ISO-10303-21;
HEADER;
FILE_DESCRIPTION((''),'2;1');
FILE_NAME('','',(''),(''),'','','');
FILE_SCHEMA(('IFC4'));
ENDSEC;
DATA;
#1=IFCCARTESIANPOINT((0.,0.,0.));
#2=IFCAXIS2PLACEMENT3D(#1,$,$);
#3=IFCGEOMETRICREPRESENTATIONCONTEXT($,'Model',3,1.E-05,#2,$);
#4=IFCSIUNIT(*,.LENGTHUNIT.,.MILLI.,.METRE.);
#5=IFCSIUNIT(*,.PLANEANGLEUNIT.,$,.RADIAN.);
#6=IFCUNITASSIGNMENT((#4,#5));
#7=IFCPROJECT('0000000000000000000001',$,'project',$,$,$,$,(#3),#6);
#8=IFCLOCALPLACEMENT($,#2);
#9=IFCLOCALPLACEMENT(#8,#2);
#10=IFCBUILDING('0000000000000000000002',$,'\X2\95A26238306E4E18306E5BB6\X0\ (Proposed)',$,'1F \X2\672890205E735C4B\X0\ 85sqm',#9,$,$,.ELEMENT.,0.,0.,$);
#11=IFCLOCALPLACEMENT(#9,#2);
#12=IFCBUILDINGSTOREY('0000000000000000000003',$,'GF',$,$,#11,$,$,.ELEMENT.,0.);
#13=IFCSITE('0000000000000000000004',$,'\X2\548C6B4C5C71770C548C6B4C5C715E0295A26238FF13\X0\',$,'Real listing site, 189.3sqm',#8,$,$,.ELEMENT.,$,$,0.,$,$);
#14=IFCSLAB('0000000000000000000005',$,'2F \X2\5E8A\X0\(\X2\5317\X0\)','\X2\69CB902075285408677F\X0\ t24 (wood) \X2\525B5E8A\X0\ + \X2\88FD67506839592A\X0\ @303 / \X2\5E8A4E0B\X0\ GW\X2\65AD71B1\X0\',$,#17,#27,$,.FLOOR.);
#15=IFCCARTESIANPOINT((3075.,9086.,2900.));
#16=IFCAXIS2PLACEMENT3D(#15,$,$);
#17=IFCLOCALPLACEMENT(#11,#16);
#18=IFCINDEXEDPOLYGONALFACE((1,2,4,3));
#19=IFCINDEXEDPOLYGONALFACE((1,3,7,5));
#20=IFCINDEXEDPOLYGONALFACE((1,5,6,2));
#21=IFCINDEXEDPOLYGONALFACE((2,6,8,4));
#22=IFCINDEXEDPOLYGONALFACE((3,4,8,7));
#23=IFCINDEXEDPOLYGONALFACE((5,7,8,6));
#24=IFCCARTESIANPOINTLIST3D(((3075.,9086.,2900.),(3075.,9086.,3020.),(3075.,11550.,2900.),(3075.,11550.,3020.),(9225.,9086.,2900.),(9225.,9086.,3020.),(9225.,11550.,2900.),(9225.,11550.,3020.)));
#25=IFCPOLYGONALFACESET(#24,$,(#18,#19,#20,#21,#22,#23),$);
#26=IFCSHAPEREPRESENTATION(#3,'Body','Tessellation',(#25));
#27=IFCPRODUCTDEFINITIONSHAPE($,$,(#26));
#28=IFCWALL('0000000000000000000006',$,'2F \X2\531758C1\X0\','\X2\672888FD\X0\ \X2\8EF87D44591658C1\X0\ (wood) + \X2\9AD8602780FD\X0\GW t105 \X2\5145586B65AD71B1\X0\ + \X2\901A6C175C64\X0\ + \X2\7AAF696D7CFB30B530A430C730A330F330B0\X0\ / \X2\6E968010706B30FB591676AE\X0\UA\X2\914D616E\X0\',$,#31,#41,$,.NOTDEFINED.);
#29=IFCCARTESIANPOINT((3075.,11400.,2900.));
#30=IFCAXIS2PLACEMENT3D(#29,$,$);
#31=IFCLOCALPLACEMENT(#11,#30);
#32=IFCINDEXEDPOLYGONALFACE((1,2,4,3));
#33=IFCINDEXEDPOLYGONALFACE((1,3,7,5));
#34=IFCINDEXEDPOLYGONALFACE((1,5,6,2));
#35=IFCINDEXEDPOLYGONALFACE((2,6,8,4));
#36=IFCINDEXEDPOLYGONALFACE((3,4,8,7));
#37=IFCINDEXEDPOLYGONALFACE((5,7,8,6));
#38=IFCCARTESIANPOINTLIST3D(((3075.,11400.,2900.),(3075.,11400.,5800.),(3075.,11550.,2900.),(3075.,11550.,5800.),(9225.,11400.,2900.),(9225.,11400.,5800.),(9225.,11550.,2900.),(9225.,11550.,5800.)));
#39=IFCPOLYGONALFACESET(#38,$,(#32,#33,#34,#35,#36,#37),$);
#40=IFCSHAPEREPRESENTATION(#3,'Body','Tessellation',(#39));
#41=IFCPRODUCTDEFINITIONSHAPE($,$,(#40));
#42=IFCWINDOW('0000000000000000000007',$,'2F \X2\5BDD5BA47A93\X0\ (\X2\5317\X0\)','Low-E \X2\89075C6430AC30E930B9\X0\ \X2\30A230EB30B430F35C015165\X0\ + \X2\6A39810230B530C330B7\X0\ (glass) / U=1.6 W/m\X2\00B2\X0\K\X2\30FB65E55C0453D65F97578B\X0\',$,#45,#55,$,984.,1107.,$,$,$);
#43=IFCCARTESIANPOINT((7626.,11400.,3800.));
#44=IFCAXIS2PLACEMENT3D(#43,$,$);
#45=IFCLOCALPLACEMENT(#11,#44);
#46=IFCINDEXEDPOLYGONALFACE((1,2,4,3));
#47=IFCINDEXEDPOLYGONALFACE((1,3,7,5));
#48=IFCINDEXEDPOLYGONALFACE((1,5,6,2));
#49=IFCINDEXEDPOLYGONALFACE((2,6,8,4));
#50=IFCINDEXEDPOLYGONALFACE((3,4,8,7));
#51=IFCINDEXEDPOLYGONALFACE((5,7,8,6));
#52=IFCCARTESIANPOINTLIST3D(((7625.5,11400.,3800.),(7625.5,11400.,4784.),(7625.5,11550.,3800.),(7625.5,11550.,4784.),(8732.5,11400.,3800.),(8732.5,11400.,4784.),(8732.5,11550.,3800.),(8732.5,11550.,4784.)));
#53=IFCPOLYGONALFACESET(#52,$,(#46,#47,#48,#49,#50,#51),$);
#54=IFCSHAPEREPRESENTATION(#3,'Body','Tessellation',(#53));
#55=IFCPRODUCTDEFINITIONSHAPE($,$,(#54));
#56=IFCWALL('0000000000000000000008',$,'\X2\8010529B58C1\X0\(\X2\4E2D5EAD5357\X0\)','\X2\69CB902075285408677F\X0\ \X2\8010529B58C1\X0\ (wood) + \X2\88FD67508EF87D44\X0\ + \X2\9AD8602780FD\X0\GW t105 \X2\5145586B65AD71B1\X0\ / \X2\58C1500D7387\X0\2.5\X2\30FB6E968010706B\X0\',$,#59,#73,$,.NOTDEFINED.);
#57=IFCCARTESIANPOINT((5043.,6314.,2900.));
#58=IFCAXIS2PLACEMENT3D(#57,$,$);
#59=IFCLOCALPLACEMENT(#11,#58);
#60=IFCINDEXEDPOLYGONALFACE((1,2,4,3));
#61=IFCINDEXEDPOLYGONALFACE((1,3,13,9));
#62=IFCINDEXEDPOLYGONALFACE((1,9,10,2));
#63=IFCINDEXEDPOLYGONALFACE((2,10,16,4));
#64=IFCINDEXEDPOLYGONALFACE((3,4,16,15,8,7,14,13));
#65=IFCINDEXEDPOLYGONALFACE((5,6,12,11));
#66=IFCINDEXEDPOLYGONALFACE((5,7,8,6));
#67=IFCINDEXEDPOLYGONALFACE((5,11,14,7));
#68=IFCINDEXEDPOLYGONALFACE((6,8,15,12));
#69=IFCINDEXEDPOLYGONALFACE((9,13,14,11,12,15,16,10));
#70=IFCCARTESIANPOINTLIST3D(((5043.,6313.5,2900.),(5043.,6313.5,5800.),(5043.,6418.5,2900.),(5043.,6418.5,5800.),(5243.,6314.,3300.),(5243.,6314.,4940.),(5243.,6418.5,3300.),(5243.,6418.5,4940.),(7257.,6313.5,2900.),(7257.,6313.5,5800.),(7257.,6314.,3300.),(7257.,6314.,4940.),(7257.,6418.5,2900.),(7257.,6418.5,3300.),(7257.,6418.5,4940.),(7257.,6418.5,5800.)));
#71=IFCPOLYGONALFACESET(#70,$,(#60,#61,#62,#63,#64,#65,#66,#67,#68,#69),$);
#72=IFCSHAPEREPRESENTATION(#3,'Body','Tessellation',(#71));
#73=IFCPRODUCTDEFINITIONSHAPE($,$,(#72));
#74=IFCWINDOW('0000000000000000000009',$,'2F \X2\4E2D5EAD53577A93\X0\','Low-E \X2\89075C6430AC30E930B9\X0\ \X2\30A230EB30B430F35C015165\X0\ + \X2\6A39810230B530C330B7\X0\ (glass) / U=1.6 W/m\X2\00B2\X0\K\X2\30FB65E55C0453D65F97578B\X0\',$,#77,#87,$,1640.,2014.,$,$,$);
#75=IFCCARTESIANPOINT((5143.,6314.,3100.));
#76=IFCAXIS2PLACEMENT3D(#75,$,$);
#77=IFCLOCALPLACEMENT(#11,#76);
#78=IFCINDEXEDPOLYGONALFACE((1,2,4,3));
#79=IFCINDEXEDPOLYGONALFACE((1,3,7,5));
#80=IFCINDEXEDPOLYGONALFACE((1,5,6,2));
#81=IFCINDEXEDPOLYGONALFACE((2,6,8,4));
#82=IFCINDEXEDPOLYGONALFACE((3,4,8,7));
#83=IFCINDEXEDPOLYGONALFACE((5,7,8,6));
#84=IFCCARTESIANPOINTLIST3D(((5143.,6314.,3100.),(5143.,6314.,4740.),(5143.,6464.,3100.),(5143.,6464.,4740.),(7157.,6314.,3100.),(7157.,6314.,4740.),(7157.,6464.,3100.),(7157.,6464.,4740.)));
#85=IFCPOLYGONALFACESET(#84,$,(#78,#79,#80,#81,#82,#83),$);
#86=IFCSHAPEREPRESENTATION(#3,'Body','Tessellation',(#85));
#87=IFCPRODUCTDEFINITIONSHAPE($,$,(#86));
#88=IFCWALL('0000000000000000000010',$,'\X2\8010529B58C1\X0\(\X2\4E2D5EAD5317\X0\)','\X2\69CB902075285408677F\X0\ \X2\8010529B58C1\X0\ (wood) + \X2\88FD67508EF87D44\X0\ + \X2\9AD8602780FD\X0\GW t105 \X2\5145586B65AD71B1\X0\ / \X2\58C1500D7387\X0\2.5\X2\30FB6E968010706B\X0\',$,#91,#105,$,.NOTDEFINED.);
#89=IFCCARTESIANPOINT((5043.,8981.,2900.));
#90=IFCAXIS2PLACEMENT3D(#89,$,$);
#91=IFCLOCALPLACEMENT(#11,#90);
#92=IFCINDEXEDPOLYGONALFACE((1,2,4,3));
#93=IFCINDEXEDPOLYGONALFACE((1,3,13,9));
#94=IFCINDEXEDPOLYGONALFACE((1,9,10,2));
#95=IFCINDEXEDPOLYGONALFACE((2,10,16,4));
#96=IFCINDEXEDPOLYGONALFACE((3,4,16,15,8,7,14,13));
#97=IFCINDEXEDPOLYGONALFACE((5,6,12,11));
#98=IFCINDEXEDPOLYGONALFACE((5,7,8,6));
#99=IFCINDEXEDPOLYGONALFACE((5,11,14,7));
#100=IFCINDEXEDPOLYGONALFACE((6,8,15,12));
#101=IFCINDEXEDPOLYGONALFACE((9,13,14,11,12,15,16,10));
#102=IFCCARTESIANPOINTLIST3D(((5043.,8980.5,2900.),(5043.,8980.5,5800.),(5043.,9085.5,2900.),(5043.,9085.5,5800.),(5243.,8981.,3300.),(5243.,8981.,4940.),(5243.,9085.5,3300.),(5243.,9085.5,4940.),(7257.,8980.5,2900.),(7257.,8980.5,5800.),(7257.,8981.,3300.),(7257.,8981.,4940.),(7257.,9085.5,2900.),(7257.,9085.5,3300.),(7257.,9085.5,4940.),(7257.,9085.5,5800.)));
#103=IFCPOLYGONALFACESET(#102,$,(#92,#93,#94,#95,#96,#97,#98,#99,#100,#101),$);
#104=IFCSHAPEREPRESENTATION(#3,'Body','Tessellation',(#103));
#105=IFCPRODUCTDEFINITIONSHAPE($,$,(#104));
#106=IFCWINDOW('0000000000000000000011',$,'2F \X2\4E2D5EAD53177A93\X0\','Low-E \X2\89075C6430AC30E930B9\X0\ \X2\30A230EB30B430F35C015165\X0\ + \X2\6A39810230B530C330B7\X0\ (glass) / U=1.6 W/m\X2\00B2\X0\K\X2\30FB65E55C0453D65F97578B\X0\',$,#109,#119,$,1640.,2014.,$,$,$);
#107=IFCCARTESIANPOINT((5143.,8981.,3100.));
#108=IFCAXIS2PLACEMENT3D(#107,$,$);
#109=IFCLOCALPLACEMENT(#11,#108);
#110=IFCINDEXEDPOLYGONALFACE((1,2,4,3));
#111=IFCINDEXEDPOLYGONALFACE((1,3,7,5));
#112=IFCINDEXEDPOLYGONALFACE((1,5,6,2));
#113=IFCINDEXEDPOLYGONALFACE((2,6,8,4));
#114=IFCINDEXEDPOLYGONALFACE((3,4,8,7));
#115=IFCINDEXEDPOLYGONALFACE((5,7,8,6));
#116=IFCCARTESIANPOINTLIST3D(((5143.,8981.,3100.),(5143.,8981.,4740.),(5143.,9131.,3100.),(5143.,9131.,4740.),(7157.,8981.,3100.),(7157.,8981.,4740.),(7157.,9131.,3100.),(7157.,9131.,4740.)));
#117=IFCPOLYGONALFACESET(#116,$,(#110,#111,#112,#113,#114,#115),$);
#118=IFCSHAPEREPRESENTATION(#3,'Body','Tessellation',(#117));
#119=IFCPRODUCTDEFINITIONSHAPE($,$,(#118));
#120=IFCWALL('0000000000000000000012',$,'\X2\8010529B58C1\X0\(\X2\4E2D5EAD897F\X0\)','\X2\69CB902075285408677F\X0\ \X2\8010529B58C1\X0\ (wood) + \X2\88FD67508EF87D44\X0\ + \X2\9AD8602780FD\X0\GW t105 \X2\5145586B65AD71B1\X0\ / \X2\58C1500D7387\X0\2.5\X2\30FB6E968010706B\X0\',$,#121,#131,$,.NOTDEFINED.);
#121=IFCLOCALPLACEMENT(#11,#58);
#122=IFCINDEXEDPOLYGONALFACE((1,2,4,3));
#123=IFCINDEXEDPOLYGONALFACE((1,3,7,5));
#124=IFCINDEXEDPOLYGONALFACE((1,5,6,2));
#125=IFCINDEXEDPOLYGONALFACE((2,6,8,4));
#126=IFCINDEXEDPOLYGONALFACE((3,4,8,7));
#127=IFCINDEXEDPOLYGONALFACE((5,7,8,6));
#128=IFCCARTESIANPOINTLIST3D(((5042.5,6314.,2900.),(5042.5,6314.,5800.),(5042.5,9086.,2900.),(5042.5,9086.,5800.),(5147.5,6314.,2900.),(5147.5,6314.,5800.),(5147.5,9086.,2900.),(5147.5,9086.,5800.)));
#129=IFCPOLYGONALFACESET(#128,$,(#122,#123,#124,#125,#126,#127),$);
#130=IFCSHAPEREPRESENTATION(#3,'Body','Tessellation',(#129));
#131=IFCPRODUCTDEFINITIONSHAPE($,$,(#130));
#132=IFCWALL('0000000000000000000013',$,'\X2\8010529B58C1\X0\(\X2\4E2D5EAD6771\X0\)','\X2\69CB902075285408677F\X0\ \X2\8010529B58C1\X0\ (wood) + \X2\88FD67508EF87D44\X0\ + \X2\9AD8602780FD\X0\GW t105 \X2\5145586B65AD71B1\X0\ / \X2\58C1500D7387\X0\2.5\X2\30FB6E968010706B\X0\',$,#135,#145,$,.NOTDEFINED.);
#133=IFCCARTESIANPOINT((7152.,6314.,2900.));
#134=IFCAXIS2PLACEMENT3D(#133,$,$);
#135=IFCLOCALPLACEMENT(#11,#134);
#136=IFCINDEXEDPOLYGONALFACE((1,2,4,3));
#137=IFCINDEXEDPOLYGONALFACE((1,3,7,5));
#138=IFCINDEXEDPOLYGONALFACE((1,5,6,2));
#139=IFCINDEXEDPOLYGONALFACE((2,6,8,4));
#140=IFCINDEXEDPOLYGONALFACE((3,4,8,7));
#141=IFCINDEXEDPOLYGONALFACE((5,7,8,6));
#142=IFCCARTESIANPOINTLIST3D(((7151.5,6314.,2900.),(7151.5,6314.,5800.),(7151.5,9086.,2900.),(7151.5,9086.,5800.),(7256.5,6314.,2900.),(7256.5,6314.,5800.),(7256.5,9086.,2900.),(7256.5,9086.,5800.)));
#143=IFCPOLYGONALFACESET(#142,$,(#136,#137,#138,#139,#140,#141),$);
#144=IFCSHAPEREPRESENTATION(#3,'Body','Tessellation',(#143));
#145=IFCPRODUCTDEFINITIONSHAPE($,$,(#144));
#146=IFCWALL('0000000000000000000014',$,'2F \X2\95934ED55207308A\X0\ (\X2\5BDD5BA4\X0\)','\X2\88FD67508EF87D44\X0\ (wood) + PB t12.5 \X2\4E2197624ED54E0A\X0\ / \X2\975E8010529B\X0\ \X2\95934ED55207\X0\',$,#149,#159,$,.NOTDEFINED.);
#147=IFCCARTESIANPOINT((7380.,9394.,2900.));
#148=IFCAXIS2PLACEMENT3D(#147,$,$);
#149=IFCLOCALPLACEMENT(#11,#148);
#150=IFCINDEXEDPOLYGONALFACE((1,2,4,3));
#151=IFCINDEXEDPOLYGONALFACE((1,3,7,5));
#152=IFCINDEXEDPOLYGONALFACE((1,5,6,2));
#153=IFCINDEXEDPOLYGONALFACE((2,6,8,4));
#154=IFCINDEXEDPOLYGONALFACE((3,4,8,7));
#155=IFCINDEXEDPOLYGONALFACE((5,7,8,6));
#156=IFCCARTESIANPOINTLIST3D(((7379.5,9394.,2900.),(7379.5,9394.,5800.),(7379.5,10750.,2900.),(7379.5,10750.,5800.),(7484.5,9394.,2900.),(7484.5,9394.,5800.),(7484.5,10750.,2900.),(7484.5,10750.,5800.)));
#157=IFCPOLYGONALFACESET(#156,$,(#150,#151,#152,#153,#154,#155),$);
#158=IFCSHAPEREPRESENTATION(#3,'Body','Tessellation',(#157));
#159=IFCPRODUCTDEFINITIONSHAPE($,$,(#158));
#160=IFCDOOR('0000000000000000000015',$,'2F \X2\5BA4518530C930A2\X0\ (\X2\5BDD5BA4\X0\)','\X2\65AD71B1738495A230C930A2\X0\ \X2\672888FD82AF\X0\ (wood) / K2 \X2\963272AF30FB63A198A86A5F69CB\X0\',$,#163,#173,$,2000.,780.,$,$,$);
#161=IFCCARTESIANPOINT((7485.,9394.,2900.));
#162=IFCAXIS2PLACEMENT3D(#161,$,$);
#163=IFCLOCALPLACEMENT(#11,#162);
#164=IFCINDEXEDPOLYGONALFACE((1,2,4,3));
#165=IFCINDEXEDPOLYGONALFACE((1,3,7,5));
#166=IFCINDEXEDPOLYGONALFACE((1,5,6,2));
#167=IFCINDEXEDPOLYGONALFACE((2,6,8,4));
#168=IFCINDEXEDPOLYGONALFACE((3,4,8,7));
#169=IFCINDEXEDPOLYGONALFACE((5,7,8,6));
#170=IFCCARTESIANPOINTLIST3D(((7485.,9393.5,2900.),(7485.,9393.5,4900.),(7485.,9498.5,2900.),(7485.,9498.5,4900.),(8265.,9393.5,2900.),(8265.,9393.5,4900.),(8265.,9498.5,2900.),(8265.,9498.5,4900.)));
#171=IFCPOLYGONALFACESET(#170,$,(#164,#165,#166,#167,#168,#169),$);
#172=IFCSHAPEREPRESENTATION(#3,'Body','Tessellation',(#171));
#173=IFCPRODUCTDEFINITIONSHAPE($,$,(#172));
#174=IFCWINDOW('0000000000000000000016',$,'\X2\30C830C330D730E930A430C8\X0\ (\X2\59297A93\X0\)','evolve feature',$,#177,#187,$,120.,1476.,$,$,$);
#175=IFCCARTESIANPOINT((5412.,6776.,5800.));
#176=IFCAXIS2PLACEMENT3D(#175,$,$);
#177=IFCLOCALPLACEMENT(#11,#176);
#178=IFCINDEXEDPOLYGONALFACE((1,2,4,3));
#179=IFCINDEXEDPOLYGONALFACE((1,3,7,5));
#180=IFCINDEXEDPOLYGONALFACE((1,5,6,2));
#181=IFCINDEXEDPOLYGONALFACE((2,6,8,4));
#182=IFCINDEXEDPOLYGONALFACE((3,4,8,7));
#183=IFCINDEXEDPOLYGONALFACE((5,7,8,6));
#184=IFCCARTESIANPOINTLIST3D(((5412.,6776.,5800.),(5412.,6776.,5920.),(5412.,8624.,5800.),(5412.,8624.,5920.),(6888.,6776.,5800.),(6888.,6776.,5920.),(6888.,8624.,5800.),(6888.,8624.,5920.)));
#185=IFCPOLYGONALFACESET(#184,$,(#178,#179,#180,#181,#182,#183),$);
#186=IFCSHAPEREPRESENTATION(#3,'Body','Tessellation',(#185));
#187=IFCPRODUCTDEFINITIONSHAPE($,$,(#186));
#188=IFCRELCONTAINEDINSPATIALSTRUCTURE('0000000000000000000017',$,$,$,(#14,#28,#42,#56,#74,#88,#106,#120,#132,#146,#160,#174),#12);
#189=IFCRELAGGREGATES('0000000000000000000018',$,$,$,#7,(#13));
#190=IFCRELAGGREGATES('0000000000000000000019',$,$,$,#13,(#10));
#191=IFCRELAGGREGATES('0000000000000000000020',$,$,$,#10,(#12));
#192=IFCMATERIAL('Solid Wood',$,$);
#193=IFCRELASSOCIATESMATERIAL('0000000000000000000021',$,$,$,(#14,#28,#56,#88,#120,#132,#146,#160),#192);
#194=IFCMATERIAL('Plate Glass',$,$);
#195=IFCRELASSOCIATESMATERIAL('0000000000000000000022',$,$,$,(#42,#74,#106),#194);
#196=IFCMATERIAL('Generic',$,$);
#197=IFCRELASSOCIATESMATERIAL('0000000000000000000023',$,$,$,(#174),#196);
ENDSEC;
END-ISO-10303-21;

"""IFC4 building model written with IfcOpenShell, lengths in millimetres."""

from ifc_helpers import new_model, si_unit, frame, frame_2d, origin, place, context, project, spatial, rectangle, extrude, material, element, fill, save


model = new_model("IFC4")

# Units and contexts
model_context = context("Model", 3, precision=1e-05, world=origin())
ifc_project = project(units=[si_unit("LENGTHUNIT", "METRE", prefix="MILLI"), si_unit("PLANEANGLEUNIT", "RADIAN")], contexts=[model_context])

# Site, building, storey
site_placement = place(None, origin())
site = spatial("IfcSite", under=ifc_project, at=site_placement, Name="和歌山県和歌山市関戸３", ObjectType="Real listing site, 189.3sqm", CompositionType="ELEMENT", RefElevation=0.0)
building_placement = place(site_placement, origin())
building = spatial("IfcBuilding", under=site, at=building_placement, Name="関戸の丘の家 (Proposed)", ObjectType="1F 木造平屋 85sqm", CompositionType="ELEMENT", ElevationOfRefHeight=0.0, ElevationOfTerrain=0.0)
storey_placement = place(building_placement, origin())
storey = spatial("IfcBuildingStorey", under=building, at=storey_placement, Name="GF", CompositionType="ELEMENT", Elevation=0.0)

# Slab
ifc_material_1 = material(Name="Solid Wood")
slab_placement = place(storey_placement, frame((3075.0, 9086.0, 2900.0)))
element("IfcSlab", 1, at=slab_placement, inside=storey, material=ifc_material_1, Name="2F 床(北)", Description="構造用合板 t24 (wood) 剛床 + 製材根太 @303 / 床下 GW断熱", PredefinedType="FLOOR", context=model_context, shape_type="SweptSolid", body=[
    extrude(rectangle(XDim=6150.0, YDim=2464.0, at=frame_2d((3075.0, 1232.0))), frame((3075.0, 9086.0, 2900.0)), (0.0, 0.0, 1.0), 120.0),
])

# Walls, openings, windows
wall_1_placement = place(storey_placement, frame((3075.0, 11400.0, 2900.0)))
wall_1 = element("IfcWall", 2, at=wall_1_placement, inside=storey, material=ifc_material_1, Name="2F 北壁", Description="木製 軸組外壁 (wood) + 高性能GW t105 充填断熱 + 通気層 + 窯業系サイディング / 準耐火・外皮UA配慮", PredefinedType="NOTDEFINED", context=model_context, shape_type="SweptSolid", body=[
    extrude(rectangle(XDim=6150.0, YDim=150.0, at=frame_2d((3075.0, 75.0))), frame((3075.0, 11400.0, 2900.0)), (0.0, 0.0, 1.0), 2900.0),
])
opening_1_placement = place(storey_placement, frame((7626.0, 11400.0, 3800.0)))
opening_1 = element("IfcOpeningElement", 3, at=opening_1_placement, cuts=wall_1, PredefinedType="NOTDEFINED", context=model_context, shape_type="SweptSolid", body=[
    extrude(rectangle(XDim=1107.0, YDim=150.0, at=frame_2d((553.0, 75.0))), frame((7626.0, 11400.0, 3800.0)), (0.0, 0.0, 1.0), 984.0),
])
ifc_material_2 = material(Name="Plate Glass")
window_1_placement = place(storey_placement, frame((7626.0, 11400.0, 3800.0)))
window_1 = element("IfcWindow", 4, at=window_1_placement, inside=storey, material=ifc_material_2, Name="2F 寝室窓 (北)", Description="Low-E 複層ガラス アルゴン封入 + 樹脂サッシ (glass) / U=1.6 W/m²K・日射取得型", OverallHeight=984.0, OverallWidth=1107.0, context=model_context, shape_type="SweptSolid", body=[
    extrude(rectangle(XDim=1107.0, YDim=150.0, at=frame_2d((553.0, 75.0))), frame((7626.0, 11400.0, 3800.0)), (0.0, 0.0, 1.0), 984.0),
])
fill(opening_1, window_1)
wall_2_placement = place(storey_placement, frame((5043.0, 6314.0, 2900.0)))
wall_2 = element("IfcWall", 5, at=wall_2_placement, inside=storey, material=ifc_material_1, Name="耐力壁(中庭南)", Description="構造用合板 耐力壁 (wood) + 製材軸組 + 高性能GW t105 充填断熱 / 壁倍率2.5・準耐火", PredefinedType="NOTDEFINED", context=model_context, shape_type="SweptSolid", body=[
    extrude(rectangle(XDim=2214.0, YDim=105.0, at=frame_2d((1107.0, 52.0))), frame((5043.0, 6314.0, 2900.0)), (0.0, 0.0, 1.0), 2900.0),
])
opening_2_placement = place(storey_placement, frame((5143.0, 6314.0, 3100.0)))
opening_2 = element("IfcOpeningElement", 6, at=opening_2_placement, cuts=wall_2, PredefinedType="NOTDEFINED", context=model_context, shape_type="SweptSolid", body=[
    extrude(rectangle(XDim=2014.0, YDim=150.0, at=frame_2d((1007.0, 75.0))), frame((5143.0, 6314.0, 3100.0)), (0.0, 0.0, 1.0), 1640.0),
])
window_2_placement = place(storey_placement, frame((5143.0, 6314.0, 3100.0)))
window_2 = element("IfcWindow", 7, at=window_2_placement, inside=storey, material=ifc_material_2, Name="2F 中庭南窓", Description="Low-E 複層ガラス アルゴン封入 + 樹脂サッシ (glass) / U=1.6 W/m²K・日射取得型", OverallHeight=1640.0, OverallWidth=2014.0, context=model_context, shape_type="SweptSolid", body=[
    extrude(rectangle(XDim=2014.0, YDim=150.0, at=frame_2d((1007.0, 75.0))), frame((5143.0, 6314.0, 3100.0)), (0.0, 0.0, 1.0), 1640.0),
])
fill(opening_2, window_2)
wall_3_placement = place(storey_placement, frame((5043.0, 8981.0, 2900.0)))
wall_3 = element("IfcWall", 8, at=wall_3_placement, inside=storey, material=ifc_material_1, Name="耐力壁(中庭北)", Description="構造用合板 耐力壁 (wood) + 製材軸組 + 高性能GW t105 充填断熱 / 壁倍率2.5・準耐火", PredefinedType="NOTDEFINED", context=model_context, shape_type="SweptSolid", body=[
    extrude(rectangle(XDim=2214.0, YDim=105.0, at=frame_2d((1107.0, 52.0))), frame((5043.0, 8981.0, 2900.0)), (0.0, 0.0, 1.0), 2900.0),
])
opening_3_placement = place(storey_placement, frame((5143.0, 8981.0, 3100.0)))
opening_3 = element("IfcOpeningElement", 9, at=opening_3_placement, cuts=wall_3, PredefinedType="NOTDEFINED", context=model_context, shape_type="SweptSolid", body=[
    extrude(rectangle(XDim=2014.0, YDim=150.0, at=frame_2d((1007.0, 75.0))), frame((5143.0, 8981.0, 3100.0)), (0.0, 0.0, 1.0), 1640.0),
])
window_3_placement = place(storey_placement, frame((5143.0, 8981.0, 3100.0)))
window_3 = element("IfcWindow", 10, at=window_3_placement, inside=storey, material=ifc_material_2, Name="2F 中庭北窓", Description="Low-E 複層ガラス アルゴン封入 + 樹脂サッシ (glass) / U=1.6 W/m²K・日射取得型", OverallHeight=1640.0, OverallWidth=2014.0, context=model_context, shape_type="SweptSolid", body=[
    extrude(rectangle(XDim=2014.0, YDim=150.0, at=frame_2d((1007.0, 75.0))), frame((5143.0, 8981.0, 3100.0)), (0.0, 0.0, 1.0), 1640.0),
])
fill(opening_3, window_3)

# Walls
wall_4_placement = place(storey_placement, frame((5043.0, 6314.0, 2900.0)))
element("IfcWall", 11, at=wall_4_placement, inside=storey, material=ifc_material_1, Name="耐力壁(中庭西)", Description="構造用合板 耐力壁 (wood) + 製材軸組 + 高性能GW t105 充填断熱 / 壁倍率2.5・準耐火", PredefinedType="NOTDEFINED", context=model_context, shape_type="SweptSolid", body=[
    extrude(rectangle(XDim=105.0, YDim=2772.0, at=frame_2d((52.0, 1386.0))), frame((5043.0, 6314.0, 2900.0)), (0.0, 0.0, 1.0), 2900.0),
])
wall_5_placement = place(storey_placement, frame((7152.0, 6314.0, 2900.0)))
element("IfcWall", 12, at=wall_5_placement, inside=storey, material=ifc_material_1, Name="耐力壁(中庭東)", Description="構造用合板 耐力壁 (wood) + 製材軸組 + 高性能GW t105 充填断熱 / 壁倍率2.5・準耐火", PredefinedType="NOTDEFINED", context=model_context, shape_type="SweptSolid", body=[
    extrude(rectangle(XDim=105.0, YDim=2772.0, at=frame_2d((52.0, 1386.0))), frame((7152.0, 6314.0, 2900.0)), (0.0, 0.0, 1.0), 2900.0),
])
wall_6_placement = place(storey_placement, frame((7380.0, 9394.0, 2900.0)))
element("IfcWall", 13, at=wall_6_placement, inside=storey, material=ifc_material_1, Name="2F 間仕切り (寝室)", Description="製材軸組 (wood) + PB t12.5 両面仕上 / 非耐力 間仕切", PredefinedType="NOTDEFINED", context=model_context, shape_type="SweptSolid", body=[
    extrude(rectangle(XDim=105.0, YDim=1356.0, at=frame_2d((52.0, 678.0))), frame((7380.0, 9394.0, 2900.0)), (0.0, 0.0, 1.0), 2900.0),
])

# Door
door_placement = place(storey_placement, frame((7485.0, 9394.0, 2900.0)))
element("IfcDoor", 14, at=door_placement, inside=storey, material=ifc_material_1, Name="2F 室内ドア (寝室)", Description="断熱玄関ドア 木製芯 (wood) / K2 防犯・採風機構", OverallHeight=2000.0, OverallWidth=780.0, context=model_context, shape_type="SweptSolid", body=[
    extrude(rectangle(XDim=780.0, YDim=105.0, at=frame_2d((390.0, 52.0))), frame((7485.0, 9394.0, 2900.0)), (0.0, 0.0, 1.0), 2000.0),
])

# Window
ifc_material_3 = material(Name="Generic")
window_4_placement = place(storey_placement, frame((5412.0, 6776.0, 5800.0)))
element("IfcWindow", 15, at=window_4_placement, inside=storey, material=ifc_material_3, Name="トップライト (天窓)", Description="evolve feature", OverallHeight=120.0, OverallWidth=1476.0, context=model_context, shape_type="SweptSolid", body=[
    extrude(rectangle(XDim=1476.0, YDim=1848.0, at=frame_2d((738.0, 924.0))), frame((5412.0, 6776.0, 5800.0)), (0.0, 0.0, 1.0), 120.0),
])

save(model, "model.ifc")
